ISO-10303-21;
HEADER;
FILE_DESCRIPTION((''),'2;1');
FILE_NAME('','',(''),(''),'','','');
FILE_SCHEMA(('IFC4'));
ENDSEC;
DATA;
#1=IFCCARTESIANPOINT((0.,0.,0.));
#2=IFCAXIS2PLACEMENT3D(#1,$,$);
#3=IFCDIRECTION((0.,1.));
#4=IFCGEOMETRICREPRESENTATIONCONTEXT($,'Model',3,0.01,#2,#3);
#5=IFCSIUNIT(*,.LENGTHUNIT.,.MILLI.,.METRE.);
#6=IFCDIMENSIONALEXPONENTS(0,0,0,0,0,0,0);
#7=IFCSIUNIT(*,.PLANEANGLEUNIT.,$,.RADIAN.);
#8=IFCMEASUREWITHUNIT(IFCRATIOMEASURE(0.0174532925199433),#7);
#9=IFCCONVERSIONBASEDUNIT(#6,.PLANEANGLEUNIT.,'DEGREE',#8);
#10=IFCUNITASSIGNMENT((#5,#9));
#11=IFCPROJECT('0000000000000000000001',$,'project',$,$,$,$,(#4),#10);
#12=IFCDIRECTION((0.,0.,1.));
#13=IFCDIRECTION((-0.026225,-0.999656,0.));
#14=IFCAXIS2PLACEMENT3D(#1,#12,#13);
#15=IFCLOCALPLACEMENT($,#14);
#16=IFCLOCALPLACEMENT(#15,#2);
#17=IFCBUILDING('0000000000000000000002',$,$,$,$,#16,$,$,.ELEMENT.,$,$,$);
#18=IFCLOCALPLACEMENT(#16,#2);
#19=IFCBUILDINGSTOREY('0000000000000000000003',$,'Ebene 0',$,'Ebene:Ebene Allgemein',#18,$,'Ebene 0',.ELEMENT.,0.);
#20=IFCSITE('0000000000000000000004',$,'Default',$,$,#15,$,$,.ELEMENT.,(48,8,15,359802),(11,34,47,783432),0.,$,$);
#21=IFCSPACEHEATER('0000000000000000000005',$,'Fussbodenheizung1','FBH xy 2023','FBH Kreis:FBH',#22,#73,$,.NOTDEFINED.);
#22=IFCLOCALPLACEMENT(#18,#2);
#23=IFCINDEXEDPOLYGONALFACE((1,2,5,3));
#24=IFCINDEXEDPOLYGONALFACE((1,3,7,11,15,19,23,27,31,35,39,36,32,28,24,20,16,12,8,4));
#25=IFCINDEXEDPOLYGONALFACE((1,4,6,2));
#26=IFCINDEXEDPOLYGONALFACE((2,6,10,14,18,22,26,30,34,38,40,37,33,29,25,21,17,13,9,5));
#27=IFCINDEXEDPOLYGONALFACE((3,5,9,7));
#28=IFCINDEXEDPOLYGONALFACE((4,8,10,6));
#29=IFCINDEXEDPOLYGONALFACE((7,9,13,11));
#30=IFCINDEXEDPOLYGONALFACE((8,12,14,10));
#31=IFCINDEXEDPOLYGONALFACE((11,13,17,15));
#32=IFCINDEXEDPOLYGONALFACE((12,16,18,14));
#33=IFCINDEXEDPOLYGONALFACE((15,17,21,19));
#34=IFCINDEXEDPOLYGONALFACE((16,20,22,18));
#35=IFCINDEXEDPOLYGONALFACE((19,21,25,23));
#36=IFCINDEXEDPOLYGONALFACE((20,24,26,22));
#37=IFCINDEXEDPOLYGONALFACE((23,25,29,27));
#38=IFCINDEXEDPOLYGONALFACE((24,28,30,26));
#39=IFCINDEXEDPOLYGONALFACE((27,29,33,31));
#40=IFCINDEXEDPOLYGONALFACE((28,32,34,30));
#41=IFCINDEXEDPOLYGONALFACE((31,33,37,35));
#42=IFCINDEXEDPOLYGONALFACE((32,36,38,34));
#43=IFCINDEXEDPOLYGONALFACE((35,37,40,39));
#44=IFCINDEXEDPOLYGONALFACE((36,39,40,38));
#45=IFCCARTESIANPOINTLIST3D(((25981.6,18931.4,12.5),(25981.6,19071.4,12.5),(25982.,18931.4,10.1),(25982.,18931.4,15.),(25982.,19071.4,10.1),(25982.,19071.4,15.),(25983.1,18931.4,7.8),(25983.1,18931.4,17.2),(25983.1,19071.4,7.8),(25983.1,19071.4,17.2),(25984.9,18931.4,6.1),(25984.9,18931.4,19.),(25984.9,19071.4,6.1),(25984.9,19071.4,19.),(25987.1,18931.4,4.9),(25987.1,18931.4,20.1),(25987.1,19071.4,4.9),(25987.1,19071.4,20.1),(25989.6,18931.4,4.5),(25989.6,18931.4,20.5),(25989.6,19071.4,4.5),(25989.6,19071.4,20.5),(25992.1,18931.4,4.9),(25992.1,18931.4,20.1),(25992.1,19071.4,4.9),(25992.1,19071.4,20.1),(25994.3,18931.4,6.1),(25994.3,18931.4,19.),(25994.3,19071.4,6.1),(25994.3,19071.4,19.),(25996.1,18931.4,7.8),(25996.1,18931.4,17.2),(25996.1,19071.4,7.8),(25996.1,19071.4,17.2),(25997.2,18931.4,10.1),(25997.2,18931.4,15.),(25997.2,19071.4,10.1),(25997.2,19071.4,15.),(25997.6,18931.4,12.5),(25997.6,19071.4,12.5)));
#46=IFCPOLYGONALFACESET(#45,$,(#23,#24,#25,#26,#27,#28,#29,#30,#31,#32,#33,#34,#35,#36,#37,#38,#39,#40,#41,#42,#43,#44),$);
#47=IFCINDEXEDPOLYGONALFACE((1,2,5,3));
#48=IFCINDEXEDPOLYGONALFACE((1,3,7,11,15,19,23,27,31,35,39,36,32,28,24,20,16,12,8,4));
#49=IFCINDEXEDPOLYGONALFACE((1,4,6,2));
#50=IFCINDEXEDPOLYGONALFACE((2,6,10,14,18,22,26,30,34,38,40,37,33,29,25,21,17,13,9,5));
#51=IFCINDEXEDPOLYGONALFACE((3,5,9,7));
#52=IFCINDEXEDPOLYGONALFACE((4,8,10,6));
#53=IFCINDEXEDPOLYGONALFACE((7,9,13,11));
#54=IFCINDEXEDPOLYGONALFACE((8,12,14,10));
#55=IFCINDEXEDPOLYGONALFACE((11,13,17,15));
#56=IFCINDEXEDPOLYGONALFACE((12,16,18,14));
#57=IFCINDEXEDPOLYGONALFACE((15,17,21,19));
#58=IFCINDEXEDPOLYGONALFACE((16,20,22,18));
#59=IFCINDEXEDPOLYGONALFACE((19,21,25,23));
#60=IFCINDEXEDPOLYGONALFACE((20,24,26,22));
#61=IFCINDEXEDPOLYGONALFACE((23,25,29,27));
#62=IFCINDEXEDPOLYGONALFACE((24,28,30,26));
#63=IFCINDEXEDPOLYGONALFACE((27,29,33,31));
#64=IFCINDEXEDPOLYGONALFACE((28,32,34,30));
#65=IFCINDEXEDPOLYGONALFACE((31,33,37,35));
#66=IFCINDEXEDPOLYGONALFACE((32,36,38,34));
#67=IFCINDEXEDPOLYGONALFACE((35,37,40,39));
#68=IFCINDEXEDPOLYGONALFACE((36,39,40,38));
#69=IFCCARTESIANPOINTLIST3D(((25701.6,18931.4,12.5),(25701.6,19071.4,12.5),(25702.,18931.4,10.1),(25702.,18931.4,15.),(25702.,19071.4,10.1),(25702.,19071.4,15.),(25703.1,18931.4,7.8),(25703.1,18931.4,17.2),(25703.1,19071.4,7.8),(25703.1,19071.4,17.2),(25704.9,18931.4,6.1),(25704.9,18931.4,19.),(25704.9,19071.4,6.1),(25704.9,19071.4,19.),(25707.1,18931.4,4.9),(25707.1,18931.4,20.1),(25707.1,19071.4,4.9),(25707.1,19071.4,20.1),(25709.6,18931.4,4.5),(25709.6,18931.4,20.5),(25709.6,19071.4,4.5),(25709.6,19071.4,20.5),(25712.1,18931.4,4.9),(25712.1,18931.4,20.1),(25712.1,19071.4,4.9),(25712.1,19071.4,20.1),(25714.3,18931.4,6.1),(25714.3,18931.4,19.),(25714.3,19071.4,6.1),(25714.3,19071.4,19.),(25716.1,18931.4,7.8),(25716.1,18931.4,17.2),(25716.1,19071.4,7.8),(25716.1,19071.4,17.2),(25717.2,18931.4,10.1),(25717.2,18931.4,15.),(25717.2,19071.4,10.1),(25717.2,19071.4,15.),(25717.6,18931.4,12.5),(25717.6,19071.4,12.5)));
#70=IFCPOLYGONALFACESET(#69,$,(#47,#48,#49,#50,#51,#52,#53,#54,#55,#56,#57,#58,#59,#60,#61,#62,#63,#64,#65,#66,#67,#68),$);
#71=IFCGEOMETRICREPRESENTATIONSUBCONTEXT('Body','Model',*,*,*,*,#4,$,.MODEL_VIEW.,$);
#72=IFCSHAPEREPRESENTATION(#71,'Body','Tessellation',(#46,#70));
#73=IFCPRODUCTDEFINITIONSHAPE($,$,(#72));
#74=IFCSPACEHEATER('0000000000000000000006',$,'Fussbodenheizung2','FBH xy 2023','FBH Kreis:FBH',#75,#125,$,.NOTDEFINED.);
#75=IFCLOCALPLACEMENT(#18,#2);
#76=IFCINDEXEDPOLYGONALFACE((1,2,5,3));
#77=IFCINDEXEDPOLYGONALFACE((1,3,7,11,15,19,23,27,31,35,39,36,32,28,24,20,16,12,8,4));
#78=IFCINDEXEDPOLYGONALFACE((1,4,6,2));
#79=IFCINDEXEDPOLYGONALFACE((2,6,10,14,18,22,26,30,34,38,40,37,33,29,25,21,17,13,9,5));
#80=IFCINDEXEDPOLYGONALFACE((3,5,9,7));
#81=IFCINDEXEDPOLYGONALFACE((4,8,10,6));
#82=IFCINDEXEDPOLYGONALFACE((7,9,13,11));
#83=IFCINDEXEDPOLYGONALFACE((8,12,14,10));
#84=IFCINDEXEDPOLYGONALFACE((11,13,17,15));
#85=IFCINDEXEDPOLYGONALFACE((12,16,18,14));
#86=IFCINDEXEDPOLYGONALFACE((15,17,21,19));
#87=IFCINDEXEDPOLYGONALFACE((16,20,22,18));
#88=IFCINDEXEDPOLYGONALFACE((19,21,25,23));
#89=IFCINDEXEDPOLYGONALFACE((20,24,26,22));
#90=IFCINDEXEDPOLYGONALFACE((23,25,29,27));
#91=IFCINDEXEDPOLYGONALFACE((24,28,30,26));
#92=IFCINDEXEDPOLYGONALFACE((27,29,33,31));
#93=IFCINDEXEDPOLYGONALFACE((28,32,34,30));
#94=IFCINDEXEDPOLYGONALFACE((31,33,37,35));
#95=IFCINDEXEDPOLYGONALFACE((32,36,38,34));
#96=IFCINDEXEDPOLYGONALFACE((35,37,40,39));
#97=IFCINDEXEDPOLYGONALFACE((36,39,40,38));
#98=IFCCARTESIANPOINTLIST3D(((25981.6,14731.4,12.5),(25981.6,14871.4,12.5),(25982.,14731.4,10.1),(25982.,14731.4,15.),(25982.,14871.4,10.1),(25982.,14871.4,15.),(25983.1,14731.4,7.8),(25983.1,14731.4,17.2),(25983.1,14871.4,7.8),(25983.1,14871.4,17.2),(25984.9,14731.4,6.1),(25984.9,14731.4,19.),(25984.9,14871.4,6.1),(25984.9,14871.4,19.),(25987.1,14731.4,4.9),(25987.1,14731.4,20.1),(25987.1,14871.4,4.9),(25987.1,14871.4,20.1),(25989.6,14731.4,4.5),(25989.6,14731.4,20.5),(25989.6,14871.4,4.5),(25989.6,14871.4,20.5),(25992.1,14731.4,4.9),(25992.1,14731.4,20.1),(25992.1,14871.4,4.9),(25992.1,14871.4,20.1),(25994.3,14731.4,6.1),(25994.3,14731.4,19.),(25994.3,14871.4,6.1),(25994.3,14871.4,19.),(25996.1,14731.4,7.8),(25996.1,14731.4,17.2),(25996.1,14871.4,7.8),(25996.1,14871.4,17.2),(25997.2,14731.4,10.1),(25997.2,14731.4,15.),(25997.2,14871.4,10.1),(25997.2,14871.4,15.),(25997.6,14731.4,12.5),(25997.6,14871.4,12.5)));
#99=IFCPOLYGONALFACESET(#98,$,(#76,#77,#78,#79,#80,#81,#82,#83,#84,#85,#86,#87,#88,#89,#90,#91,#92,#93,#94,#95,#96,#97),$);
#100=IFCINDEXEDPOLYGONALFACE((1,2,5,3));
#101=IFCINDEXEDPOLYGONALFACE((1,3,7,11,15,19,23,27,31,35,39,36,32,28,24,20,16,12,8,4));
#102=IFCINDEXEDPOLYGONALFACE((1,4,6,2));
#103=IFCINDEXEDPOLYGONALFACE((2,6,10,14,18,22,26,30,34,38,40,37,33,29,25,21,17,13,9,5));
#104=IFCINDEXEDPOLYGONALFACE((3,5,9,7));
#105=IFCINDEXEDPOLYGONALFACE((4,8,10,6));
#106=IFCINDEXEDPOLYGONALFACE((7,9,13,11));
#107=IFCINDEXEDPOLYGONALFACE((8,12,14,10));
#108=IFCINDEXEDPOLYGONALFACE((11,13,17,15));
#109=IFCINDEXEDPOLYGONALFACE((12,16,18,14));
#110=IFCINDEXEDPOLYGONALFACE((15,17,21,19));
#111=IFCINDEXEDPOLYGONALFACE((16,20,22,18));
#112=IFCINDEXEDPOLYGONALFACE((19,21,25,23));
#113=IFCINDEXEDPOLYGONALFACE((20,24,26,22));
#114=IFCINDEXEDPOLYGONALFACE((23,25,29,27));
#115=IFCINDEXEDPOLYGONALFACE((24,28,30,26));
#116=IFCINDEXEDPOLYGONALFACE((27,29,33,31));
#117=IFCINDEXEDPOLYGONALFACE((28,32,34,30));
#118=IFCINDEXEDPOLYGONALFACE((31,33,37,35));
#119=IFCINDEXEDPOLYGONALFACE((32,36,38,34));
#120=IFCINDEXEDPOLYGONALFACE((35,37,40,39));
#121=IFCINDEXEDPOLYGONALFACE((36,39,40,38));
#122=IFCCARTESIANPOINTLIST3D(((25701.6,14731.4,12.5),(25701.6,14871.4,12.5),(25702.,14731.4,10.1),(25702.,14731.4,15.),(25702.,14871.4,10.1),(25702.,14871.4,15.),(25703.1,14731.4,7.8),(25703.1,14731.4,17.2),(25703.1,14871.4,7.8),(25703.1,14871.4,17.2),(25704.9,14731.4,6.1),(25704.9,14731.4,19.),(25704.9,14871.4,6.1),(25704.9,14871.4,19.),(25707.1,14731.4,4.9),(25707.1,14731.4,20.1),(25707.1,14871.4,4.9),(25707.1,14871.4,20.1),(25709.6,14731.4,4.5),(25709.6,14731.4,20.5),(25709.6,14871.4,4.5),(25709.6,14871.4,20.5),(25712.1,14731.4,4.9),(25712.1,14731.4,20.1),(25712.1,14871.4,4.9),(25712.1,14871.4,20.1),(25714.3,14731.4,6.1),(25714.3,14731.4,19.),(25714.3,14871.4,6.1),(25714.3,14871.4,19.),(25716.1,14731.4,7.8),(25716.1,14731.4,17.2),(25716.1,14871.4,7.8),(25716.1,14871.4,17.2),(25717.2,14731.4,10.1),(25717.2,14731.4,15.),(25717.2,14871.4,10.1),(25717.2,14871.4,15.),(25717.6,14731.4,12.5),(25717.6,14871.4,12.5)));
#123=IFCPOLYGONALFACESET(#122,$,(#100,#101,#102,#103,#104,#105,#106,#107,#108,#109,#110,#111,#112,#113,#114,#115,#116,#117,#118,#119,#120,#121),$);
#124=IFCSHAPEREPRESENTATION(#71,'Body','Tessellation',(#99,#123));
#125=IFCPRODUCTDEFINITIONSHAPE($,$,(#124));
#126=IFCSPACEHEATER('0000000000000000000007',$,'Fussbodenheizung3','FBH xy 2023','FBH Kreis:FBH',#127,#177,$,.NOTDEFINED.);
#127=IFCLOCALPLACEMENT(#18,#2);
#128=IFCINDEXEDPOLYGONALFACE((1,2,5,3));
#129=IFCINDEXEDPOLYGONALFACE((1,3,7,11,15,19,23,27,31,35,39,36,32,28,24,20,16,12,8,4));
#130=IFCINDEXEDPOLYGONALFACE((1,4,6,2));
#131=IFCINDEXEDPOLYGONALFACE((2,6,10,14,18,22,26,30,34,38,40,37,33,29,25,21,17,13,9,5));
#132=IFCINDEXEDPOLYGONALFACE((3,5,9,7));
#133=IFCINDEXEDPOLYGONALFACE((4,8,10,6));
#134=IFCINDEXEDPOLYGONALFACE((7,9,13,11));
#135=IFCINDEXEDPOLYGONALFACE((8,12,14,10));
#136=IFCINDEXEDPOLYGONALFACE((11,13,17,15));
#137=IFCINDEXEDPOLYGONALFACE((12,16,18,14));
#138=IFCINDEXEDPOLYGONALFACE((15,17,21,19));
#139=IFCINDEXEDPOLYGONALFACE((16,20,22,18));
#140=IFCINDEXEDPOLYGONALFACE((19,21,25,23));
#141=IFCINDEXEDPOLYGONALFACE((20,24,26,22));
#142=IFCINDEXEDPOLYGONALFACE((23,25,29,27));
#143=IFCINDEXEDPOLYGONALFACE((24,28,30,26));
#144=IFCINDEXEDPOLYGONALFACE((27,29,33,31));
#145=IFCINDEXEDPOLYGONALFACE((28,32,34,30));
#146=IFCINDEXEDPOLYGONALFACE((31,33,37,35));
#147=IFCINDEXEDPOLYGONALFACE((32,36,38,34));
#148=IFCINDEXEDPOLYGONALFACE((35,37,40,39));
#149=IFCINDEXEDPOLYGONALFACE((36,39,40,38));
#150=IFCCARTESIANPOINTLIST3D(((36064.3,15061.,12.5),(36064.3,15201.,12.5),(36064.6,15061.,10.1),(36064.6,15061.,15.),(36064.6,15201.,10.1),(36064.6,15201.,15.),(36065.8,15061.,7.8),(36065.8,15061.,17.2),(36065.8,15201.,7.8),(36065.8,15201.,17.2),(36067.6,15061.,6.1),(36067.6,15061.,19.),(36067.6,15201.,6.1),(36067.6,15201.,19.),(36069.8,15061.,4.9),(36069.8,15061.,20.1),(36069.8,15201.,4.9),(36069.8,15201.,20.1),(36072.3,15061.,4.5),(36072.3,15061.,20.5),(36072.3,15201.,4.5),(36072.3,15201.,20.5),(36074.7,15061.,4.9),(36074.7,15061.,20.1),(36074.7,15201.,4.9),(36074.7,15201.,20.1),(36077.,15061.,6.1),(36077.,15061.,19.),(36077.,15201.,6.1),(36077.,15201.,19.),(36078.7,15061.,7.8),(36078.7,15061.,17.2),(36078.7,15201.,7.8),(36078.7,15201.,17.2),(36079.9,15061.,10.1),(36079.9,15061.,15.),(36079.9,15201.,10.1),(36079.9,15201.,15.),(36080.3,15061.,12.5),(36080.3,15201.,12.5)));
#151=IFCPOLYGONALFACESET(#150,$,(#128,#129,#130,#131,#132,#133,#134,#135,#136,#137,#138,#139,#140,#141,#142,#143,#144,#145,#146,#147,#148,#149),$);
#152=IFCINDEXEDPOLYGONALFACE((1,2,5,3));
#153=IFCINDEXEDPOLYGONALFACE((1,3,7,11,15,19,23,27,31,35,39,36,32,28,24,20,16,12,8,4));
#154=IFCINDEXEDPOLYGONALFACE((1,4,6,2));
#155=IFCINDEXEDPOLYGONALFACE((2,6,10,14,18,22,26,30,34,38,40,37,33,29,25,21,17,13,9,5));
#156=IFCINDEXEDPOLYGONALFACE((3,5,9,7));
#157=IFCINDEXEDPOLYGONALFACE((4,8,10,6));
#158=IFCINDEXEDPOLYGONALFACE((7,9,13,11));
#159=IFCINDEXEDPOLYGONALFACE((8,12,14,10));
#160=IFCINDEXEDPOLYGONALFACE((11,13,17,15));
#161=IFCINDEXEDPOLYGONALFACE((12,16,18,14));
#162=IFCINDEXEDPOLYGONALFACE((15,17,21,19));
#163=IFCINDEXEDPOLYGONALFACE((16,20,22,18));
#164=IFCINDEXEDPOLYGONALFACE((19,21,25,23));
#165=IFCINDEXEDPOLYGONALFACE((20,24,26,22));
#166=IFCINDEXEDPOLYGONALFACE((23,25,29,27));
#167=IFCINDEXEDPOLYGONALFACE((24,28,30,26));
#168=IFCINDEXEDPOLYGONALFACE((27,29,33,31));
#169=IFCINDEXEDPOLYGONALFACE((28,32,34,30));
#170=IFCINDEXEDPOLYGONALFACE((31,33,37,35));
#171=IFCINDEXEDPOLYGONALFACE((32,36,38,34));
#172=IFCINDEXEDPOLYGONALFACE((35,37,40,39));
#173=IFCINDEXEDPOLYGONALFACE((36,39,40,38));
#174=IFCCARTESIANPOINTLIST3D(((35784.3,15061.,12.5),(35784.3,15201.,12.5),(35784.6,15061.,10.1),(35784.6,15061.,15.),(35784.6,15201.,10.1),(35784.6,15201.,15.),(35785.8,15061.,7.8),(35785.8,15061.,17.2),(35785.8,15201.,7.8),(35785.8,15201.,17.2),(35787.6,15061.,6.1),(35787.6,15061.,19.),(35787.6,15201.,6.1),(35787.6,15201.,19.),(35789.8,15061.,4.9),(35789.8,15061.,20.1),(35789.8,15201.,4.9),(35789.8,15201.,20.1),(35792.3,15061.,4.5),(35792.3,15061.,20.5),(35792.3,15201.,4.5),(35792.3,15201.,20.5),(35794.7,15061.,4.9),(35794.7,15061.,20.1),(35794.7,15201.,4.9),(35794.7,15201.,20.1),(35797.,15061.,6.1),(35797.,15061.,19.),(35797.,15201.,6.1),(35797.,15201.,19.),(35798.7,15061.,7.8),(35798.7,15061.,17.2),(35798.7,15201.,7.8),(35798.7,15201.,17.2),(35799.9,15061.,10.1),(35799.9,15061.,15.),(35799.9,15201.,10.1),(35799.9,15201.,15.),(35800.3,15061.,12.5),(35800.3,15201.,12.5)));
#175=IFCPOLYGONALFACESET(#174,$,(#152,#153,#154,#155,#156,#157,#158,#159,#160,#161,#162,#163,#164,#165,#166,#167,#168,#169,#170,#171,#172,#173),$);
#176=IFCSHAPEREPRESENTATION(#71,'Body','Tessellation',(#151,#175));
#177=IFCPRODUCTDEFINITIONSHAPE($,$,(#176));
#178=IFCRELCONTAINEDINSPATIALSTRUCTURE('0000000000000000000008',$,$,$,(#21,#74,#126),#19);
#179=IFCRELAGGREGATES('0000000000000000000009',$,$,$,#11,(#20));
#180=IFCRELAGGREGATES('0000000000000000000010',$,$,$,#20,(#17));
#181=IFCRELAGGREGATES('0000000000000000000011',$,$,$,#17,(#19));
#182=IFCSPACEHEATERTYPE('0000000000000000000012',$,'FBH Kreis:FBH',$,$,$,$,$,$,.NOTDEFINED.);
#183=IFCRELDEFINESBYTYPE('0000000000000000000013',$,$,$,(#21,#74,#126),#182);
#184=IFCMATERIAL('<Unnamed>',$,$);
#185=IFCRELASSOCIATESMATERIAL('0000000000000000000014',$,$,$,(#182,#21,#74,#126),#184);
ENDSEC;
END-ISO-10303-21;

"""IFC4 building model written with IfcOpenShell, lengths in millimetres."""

from ifc_helpers import new_model, entity, si_unit, converted_unit, direction, frame, origin, place, context, subcontext, project, spatial, indexed_curve, outline, extrude, source, transform, mapped, material, type_object, type_shapes, element, save


model = new_model("IFC4")

# Units and contexts
model_context = context("Model", 3, precision=0.01, world=origin(), true_north=direction((0.0, 1.0)))
body_context = subcontext(model_context, "Body", "Model", "MODEL_VIEW")
ifc_project = project(units=[si_unit("LENGTHUNIT", "METRE", prefix="MILLI"), converted_unit("PLANEANGLEUNIT", "DEGREE", entity("IfcRatioMeasure", 0.0174532925199433), si_unit("PLANEANGLEUNIT", "RADIAN"), dimensions=[0, 0, 0, 0, 0, 0, 0])], contexts=[model_context])

# Site, building, storey
site_placement = place(None, frame((0.0, 0.0, 0.0), z_axis=(0.0, 0.0, 1.0), x_axis=(-0.026225, -0.999656, 0.0)))
site = spatial("IfcSite", under=ifc_project, at=site_placement, Name="Default", CompositionType="ELEMENT", RefLatitude=(48, 8, 15, 359802), RefLongitude=(11, 34, 47, 783432), RefElevation=0.0)
building_placement = place(site_placement, origin())
building = spatial("IfcBuilding", under=site, at=building_placement, CompositionType="ELEMENT")
storey_placement = place(building_placement, origin())
storey = spatial("IfcBuildingStorey", under=building, at=storey_placement, Name="Ebene 0", ObjectType="Ebene:Ebene Allgemein", LongName="Ebene 0", CompositionType="ELEMENT", Elevation=0.0)

# Space heaters
ifc_material = material(Name="<Unnamed>")
space_heater_type = type_object("IfcSpaceHeaterType", Name="FBH Kreis:FBH", PredefinedType="NOTDEFINED", material=ifc_material)
shared_shape = source(origin(), body_context, "Body", "SweptSolid", [
    extrude(outline(indexed_curve([(8.0, 0.0), (7.6, 2.5), (6.5, 4.7), (4.7, 6.5), (2.5, 7.6), (0.0, 8.0), (-2.5, 7.6), (-4.7, 6.5), (-6.5, 4.7), (-7.6, 2.5), (-8.0, 0.0), (-7.6, -2.5), (-6.5, -4.7), (-4.7, -6.5), (-2.5, -7.6), (0.0, -8.0), (2.5, -7.6), (4.7, -6.5), (6.5, -4.7), (7.6, -2.5), (8.0, 0.0)], self_intersect=False)), frame((140.0, -1621.8, -83.0), z_axis=(0.0, 1.0, 0.0), x_axis=(1.0, 0.0, 0.0)), (0.0, 0.0, 1.0), 140.0),
    extrude(outline(indexed_curve([(8.0, 0.0), (7.6, 2.5), (6.5, 4.7), (4.7, 6.5), (2.5, 7.6), (0.0, 8.0), (-2.5, 7.6), (-4.7, 6.5), (-6.5, 4.7), (-7.6, 2.5), (-8.0, 0.0), (-7.6, -2.5), (-6.5, -4.7), (-4.7, -6.5), (-2.5, -7.6), (0.0, -8.0), (2.5, -7.6), (4.7, -6.5), (6.5, -4.7), (7.6, -2.5), (8.0, 0.0)], self_intersect=False)), frame((-140.0, -1621.8, -83.0), z_axis=(0.0, 1.0, 0.0), x_axis=(1.0, 0.0, 0.0)), (0.0, 0.0, 1.0), 140.0),
])
type_shapes(space_heater_type, [shared_shape])
for number, where, name in (
    (1, (25849.6, 20553.2, 95.5), "Fussbodenheizung1"),
    (2, (25849.6, 16353.2, 95.5), "Fussbodenheizung2"),
    (3, (35932.3, 16682.8, 95.5), "Fussbodenheizung3"),
):
    element("IfcSpaceHeater", number, at=place(storey_placement, frame(where)), inside=storey, type_object=space_heater_type, material=ifc_material, Name=name, Description="FBH xy 2023", ObjectType="FBH Kreis:FBH", PredefinedType="NOTDEFINED", context=body_context, shape_type="MappedRepresentation", body=[
        mapped(shared_shape, transform((0.0, 0.0, 0.0), scale=1.0)),
    ])

save(model, "model.ifc")
